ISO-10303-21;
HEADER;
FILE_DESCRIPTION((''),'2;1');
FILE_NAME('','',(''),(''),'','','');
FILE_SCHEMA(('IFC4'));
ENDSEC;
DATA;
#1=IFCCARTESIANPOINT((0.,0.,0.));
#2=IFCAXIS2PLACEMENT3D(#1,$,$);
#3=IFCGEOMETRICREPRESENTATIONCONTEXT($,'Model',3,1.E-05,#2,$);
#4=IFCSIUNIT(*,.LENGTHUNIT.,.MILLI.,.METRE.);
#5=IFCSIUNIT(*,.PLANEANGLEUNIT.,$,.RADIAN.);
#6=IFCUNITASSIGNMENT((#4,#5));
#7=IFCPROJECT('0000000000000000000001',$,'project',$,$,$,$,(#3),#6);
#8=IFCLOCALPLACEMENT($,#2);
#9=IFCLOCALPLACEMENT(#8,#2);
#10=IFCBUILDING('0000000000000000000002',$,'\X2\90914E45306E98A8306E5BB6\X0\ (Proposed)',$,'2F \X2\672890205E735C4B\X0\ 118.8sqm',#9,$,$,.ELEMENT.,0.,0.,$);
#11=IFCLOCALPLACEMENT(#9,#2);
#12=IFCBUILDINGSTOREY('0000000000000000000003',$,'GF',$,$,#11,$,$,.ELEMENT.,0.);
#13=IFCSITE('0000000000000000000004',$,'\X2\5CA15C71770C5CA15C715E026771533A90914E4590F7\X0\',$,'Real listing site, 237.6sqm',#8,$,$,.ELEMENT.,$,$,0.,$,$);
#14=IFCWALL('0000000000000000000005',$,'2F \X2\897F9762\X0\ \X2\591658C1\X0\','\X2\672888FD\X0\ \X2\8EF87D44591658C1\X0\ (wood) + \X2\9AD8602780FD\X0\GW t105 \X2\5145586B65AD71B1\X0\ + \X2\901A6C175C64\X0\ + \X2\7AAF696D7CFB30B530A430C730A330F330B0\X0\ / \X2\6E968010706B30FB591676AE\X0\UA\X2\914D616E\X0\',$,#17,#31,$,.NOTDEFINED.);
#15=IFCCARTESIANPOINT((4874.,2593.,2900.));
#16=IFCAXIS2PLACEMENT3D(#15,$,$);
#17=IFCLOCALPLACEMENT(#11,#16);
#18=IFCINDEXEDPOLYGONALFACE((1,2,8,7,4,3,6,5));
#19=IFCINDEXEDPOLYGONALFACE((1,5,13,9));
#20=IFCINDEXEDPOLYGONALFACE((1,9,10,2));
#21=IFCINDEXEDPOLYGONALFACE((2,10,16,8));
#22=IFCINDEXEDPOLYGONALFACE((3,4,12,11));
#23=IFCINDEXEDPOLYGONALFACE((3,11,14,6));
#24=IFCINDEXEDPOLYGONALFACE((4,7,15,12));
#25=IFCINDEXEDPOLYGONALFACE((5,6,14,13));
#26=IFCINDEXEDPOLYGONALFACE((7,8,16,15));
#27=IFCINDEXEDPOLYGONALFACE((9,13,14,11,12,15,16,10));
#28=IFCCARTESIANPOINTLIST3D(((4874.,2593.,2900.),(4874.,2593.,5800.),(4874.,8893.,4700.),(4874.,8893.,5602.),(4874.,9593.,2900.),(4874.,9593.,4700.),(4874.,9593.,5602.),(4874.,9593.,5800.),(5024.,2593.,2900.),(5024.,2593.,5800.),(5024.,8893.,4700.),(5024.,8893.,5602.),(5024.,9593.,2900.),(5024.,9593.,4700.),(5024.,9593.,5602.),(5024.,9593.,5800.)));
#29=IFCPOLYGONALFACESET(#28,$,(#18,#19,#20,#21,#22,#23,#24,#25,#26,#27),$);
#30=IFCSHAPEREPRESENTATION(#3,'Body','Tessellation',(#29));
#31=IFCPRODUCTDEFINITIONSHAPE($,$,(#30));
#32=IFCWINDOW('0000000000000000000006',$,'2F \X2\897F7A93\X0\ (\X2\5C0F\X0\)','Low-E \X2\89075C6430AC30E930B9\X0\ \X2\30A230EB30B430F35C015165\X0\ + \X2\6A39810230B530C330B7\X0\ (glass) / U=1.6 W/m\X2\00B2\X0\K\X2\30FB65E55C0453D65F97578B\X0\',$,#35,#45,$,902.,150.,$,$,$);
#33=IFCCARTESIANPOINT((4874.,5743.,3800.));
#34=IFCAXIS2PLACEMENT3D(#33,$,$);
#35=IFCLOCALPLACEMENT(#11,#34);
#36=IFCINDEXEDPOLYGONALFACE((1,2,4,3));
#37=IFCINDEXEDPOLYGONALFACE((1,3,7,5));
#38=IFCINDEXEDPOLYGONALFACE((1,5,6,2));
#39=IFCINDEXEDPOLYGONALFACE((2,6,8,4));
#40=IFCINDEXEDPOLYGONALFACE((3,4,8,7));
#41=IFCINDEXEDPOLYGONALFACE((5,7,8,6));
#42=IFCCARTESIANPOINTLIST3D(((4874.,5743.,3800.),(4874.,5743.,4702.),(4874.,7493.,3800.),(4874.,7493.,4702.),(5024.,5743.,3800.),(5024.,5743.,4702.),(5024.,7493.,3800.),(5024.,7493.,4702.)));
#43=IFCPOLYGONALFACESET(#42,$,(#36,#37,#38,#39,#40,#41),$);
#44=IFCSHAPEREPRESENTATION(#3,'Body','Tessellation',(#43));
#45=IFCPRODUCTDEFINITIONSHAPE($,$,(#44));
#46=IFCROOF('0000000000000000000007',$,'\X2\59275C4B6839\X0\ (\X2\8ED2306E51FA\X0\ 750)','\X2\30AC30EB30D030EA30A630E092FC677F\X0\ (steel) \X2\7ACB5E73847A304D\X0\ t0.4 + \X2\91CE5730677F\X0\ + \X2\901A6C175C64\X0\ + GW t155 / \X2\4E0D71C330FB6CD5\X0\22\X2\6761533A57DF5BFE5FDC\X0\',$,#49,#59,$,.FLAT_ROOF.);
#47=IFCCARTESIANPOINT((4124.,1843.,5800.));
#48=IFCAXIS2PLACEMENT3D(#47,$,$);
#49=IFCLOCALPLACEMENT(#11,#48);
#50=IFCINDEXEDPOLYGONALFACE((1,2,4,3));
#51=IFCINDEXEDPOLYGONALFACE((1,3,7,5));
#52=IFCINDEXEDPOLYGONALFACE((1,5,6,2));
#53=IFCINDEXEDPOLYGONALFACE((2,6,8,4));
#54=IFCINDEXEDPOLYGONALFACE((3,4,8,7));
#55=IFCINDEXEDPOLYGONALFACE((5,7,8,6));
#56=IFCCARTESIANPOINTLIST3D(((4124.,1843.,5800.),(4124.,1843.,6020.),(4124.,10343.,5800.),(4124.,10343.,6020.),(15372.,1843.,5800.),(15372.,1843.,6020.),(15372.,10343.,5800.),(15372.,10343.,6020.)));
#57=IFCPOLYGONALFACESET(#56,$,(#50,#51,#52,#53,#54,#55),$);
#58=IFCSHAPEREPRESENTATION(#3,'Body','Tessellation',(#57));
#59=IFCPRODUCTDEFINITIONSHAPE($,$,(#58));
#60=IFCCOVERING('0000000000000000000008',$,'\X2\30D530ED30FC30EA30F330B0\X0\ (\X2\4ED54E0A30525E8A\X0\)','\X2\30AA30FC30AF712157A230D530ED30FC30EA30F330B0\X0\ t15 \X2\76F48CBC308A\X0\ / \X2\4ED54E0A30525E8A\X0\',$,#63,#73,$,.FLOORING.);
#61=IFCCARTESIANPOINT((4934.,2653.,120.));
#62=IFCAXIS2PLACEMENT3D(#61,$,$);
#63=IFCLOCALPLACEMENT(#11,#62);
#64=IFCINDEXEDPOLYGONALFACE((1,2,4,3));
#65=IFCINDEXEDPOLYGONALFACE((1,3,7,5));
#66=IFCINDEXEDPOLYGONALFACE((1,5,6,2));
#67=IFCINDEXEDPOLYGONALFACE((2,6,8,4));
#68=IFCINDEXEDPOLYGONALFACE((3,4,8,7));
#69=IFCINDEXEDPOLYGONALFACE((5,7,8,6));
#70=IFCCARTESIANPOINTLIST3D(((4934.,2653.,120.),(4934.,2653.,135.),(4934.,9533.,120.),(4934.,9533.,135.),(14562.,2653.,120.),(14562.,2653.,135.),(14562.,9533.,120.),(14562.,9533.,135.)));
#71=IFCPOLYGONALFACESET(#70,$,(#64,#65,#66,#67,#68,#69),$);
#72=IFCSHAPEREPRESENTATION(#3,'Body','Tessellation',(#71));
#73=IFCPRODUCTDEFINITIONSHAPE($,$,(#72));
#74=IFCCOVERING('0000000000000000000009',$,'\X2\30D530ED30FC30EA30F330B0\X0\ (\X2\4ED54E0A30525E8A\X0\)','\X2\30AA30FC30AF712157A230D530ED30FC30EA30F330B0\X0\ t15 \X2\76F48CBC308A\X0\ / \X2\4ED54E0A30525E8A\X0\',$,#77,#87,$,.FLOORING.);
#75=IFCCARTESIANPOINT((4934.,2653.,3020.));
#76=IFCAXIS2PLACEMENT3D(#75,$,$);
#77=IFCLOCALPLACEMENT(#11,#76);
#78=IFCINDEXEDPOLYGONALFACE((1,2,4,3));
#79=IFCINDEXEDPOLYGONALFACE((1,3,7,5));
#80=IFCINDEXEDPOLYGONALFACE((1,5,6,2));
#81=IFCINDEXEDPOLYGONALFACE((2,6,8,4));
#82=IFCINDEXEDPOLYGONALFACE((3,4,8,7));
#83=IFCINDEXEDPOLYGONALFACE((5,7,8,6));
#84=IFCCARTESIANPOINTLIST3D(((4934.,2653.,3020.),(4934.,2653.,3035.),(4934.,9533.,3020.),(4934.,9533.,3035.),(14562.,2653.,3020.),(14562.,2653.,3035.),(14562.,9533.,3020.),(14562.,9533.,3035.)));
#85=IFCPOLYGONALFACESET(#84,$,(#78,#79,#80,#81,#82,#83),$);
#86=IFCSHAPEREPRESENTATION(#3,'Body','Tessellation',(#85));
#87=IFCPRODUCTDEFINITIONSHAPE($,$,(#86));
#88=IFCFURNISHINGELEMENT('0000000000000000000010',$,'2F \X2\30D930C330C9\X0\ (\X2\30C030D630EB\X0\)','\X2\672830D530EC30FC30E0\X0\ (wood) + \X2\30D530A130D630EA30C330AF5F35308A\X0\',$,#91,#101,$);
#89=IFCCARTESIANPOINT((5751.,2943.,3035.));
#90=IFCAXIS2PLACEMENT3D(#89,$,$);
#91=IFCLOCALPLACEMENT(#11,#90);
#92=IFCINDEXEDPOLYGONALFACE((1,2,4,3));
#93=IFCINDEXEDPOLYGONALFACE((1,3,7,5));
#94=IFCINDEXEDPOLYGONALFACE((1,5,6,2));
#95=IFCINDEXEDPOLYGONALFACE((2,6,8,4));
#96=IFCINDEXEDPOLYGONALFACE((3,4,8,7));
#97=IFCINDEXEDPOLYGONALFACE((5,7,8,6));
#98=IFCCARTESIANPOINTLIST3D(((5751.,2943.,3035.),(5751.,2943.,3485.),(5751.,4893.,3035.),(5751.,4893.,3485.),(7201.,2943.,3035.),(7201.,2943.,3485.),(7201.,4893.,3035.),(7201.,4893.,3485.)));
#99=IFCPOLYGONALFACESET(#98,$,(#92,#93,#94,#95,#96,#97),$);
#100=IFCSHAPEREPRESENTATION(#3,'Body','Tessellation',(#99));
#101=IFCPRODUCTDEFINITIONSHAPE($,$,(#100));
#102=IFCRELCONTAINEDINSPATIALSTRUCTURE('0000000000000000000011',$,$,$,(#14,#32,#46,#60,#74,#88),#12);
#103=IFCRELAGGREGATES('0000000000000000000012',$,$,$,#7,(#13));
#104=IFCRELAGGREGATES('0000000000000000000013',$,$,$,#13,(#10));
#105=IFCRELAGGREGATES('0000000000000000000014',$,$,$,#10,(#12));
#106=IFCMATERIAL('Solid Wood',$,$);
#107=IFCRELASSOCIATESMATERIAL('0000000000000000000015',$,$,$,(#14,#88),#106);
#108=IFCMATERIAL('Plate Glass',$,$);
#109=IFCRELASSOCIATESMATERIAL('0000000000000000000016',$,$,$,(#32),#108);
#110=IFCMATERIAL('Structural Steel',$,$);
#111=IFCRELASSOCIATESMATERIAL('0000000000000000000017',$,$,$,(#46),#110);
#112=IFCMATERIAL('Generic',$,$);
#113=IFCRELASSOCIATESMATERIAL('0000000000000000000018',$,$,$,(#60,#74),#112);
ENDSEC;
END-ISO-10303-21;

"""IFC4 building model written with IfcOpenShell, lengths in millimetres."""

from ifc_helpers import new_model, si_unit, frame, frame_2d, origin, place, context, project, spatial, rectangle, extrude, material, element, fill, save


model = new_model("IFC4")

# Units and contexts
model_context = context("Model", 3, precision=1e-05, world=origin())
ifc_project = project(units=[si_unit("LENGTHUNIT", "METRE", prefix="MILLI"), si_unit("PLANEANGLEUNIT", "RADIAN")], contexts=[model_context])

# Site, building, storey
site_placement = place(None, origin())
site = spatial("IfcSite", under=ifc_project, at=site_placement, Name="岡山県岡山市東区邑久郷", ObjectType="Real listing site, 237.6sqm", CompositionType="ELEMENT", RefElevation=0.0)
building_placement = place(site_placement, origin())
building = spatial("IfcBuilding", under=site, at=building_placement, Name="邑久の風の家 (Proposed)", ObjectType="2F 木造平屋 118.8sqm", CompositionType="ELEMENT", ElevationOfRefHeight=0.0, ElevationOfTerrain=0.0)
storey_placement = place(building_placement, origin())
storey = spatial("IfcBuildingStorey", under=building, at=storey_placement, Name="GF", CompositionType="ELEMENT", Elevation=0.0)

# Shared definitions
ifc_material_1 = material(Name="Solid Wood")

# Shared definitions
ifc_material_2 = material(Name="Plate Glass")

# Wall, opening, window
wall_1_placement = place(storey_placement, frame((4874.0, 2593.0, 2900.0)))
wall_1 = element("IfcWall", 1, at=wall_1_placement, inside=storey, material=ifc_material_1, Name="2F 西面 外壁", Description="木製 軸組外壁 (wood) + 高性能GW t105 充填断熱 + 通気層 + 窯業系サイディング / 準耐火・外皮UA配慮", PredefinedType="NOTDEFINED", context=model_context, shape_type="SweptSolid", body=[
    extrude(rectangle(XDim=150.0, YDim=7000.0, at=frame_2d((75.0, 3500.0))), frame((4874.0, 2593.0, 2900.0)), (0.0, 0.0, 1.0), 2900.0),
])
opening_1_placement = place(storey_placement, frame((4874.0, 5743.0, 3800.0)))
opening_1 = element("IfcOpeningElement", 2, at=opening_1_placement, cuts=wall_1, PredefinedType="NOTDEFINED", context=model_context, shape_type="SweptSolid", body=[
    extrude(rectangle(XDim=150.0, YDim=1750.0, at=frame_2d((75.0, 875.0))), frame((4874.0, 5743.0, 3800.0)), (0.0, 0.0, 1.0), 902.0),
])
window_1_placement = place(storey_placement, frame((4874.0, 5743.0, 3800.0)))
window_1 = element("IfcWindow", 3, at=window_1_placement, inside=storey, material=ifc_material_2, Name="2F 西窓 (小)", Description="Low-E 複層ガラス アルゴン封入 + 樹脂サッシ (glass) / U=1.6 W/m²K・日射取得型", OverallHeight=902.0, OverallWidth=150.0, context=model_context, shape_type="SweptSolid", body=[
    extrude(rectangle(XDim=150.0, YDim=1750.0, at=frame_2d((75.0, 875.0))), frame((4874.0, 5743.0, 3800.0)), (0.0, 0.0, 1.0), 902.0),
])
fill(opening_1, window_1)

# Roof
ifc_material_3 = material(Name="Structural Steel")
roof_placement = place(storey_placement, frame((4124.0, 1843.0, 5800.0)))
element("IfcRoof", 4, at=roof_placement, inside=storey, material=ifc_material_3, Name="大屋根 (軒の出 750)", Description="ガルバリウム鋼板 (steel) 立平葺き t0.4 + 野地板 + 通気層 + GW t155 / 不燃・法22条区域対応", PredefinedType="FLAT_ROOF", context=model_context, shape_type="SweptSolid", body=[
    extrude(rectangle(XDim=11248.0, YDim=8500.0, at=frame_2d((5624.0, 4250.0))), frame((4124.0, 1843.0, 5800.0)), (0.0, 0.0, 1.0), 220.0),
])

# Coverings
ifc_material_4 = material(Name="Generic")
covering_1_placement = place(storey_placement, frame((4934.0, 2653.0, 120.0)))
element("IfcCovering", 5, at=covering_1_placement, inside=storey, material=ifc_material_4, Name="フローリング (仕上げ床)", Description="オーク無垢フローリング t15 直貼り / 仕上げ床", PredefinedType="FLOORING", context=model_context, shape_type="SweptSolid", body=[
    extrude(rectangle(XDim=9628.0, YDim=6880.0, at=frame_2d((4814.0, 3440.0))), frame((4934.0, 2653.0, 120.0)), (0.0, 0.0, 1.0), 15.0),
])
covering_2_placement = place(storey_placement, frame((4934.0, 2653.0, 3020.0)))
element("IfcCovering", 6, at=covering_2_placement, inside=storey, material=ifc_material_4, Name="フローリング (仕上げ床)", Description="オーク無垢フローリング t15 直貼り / 仕上げ床", PredefinedType="FLOORING", context=model_context, shape_type="SweptSolid", body=[
    extrude(rectangle(XDim=9628.0, YDim=6880.0, at=frame_2d((4814.0, 3440.0))), frame((4934.0, 2653.0, 3020.0)), (0.0, 0.0, 1.0), 15.0),
])

# Furnishing element
furnishing_placement = place(storey_placement, frame((5751.0, 2943.0, 3035.0)))
element("IfcFurnishingElement", 7, at=furnishing_placement, inside=storey, material=ifc_material_1, Name="2F ベッド (ダブル)", Description="木フレーム (wood) + ファブリック張り", context=model_context, shape_type="SweptSolid", body=[
    extrude(rectangle(XDim=1450.0, YDim=1950.0, at=frame_2d((725.0, 975.0))), frame((5751.0, 2943.0, 3035.0)), (0.0, 0.0, 1.0), 450.0),
])

save(model, "model.ifc")
